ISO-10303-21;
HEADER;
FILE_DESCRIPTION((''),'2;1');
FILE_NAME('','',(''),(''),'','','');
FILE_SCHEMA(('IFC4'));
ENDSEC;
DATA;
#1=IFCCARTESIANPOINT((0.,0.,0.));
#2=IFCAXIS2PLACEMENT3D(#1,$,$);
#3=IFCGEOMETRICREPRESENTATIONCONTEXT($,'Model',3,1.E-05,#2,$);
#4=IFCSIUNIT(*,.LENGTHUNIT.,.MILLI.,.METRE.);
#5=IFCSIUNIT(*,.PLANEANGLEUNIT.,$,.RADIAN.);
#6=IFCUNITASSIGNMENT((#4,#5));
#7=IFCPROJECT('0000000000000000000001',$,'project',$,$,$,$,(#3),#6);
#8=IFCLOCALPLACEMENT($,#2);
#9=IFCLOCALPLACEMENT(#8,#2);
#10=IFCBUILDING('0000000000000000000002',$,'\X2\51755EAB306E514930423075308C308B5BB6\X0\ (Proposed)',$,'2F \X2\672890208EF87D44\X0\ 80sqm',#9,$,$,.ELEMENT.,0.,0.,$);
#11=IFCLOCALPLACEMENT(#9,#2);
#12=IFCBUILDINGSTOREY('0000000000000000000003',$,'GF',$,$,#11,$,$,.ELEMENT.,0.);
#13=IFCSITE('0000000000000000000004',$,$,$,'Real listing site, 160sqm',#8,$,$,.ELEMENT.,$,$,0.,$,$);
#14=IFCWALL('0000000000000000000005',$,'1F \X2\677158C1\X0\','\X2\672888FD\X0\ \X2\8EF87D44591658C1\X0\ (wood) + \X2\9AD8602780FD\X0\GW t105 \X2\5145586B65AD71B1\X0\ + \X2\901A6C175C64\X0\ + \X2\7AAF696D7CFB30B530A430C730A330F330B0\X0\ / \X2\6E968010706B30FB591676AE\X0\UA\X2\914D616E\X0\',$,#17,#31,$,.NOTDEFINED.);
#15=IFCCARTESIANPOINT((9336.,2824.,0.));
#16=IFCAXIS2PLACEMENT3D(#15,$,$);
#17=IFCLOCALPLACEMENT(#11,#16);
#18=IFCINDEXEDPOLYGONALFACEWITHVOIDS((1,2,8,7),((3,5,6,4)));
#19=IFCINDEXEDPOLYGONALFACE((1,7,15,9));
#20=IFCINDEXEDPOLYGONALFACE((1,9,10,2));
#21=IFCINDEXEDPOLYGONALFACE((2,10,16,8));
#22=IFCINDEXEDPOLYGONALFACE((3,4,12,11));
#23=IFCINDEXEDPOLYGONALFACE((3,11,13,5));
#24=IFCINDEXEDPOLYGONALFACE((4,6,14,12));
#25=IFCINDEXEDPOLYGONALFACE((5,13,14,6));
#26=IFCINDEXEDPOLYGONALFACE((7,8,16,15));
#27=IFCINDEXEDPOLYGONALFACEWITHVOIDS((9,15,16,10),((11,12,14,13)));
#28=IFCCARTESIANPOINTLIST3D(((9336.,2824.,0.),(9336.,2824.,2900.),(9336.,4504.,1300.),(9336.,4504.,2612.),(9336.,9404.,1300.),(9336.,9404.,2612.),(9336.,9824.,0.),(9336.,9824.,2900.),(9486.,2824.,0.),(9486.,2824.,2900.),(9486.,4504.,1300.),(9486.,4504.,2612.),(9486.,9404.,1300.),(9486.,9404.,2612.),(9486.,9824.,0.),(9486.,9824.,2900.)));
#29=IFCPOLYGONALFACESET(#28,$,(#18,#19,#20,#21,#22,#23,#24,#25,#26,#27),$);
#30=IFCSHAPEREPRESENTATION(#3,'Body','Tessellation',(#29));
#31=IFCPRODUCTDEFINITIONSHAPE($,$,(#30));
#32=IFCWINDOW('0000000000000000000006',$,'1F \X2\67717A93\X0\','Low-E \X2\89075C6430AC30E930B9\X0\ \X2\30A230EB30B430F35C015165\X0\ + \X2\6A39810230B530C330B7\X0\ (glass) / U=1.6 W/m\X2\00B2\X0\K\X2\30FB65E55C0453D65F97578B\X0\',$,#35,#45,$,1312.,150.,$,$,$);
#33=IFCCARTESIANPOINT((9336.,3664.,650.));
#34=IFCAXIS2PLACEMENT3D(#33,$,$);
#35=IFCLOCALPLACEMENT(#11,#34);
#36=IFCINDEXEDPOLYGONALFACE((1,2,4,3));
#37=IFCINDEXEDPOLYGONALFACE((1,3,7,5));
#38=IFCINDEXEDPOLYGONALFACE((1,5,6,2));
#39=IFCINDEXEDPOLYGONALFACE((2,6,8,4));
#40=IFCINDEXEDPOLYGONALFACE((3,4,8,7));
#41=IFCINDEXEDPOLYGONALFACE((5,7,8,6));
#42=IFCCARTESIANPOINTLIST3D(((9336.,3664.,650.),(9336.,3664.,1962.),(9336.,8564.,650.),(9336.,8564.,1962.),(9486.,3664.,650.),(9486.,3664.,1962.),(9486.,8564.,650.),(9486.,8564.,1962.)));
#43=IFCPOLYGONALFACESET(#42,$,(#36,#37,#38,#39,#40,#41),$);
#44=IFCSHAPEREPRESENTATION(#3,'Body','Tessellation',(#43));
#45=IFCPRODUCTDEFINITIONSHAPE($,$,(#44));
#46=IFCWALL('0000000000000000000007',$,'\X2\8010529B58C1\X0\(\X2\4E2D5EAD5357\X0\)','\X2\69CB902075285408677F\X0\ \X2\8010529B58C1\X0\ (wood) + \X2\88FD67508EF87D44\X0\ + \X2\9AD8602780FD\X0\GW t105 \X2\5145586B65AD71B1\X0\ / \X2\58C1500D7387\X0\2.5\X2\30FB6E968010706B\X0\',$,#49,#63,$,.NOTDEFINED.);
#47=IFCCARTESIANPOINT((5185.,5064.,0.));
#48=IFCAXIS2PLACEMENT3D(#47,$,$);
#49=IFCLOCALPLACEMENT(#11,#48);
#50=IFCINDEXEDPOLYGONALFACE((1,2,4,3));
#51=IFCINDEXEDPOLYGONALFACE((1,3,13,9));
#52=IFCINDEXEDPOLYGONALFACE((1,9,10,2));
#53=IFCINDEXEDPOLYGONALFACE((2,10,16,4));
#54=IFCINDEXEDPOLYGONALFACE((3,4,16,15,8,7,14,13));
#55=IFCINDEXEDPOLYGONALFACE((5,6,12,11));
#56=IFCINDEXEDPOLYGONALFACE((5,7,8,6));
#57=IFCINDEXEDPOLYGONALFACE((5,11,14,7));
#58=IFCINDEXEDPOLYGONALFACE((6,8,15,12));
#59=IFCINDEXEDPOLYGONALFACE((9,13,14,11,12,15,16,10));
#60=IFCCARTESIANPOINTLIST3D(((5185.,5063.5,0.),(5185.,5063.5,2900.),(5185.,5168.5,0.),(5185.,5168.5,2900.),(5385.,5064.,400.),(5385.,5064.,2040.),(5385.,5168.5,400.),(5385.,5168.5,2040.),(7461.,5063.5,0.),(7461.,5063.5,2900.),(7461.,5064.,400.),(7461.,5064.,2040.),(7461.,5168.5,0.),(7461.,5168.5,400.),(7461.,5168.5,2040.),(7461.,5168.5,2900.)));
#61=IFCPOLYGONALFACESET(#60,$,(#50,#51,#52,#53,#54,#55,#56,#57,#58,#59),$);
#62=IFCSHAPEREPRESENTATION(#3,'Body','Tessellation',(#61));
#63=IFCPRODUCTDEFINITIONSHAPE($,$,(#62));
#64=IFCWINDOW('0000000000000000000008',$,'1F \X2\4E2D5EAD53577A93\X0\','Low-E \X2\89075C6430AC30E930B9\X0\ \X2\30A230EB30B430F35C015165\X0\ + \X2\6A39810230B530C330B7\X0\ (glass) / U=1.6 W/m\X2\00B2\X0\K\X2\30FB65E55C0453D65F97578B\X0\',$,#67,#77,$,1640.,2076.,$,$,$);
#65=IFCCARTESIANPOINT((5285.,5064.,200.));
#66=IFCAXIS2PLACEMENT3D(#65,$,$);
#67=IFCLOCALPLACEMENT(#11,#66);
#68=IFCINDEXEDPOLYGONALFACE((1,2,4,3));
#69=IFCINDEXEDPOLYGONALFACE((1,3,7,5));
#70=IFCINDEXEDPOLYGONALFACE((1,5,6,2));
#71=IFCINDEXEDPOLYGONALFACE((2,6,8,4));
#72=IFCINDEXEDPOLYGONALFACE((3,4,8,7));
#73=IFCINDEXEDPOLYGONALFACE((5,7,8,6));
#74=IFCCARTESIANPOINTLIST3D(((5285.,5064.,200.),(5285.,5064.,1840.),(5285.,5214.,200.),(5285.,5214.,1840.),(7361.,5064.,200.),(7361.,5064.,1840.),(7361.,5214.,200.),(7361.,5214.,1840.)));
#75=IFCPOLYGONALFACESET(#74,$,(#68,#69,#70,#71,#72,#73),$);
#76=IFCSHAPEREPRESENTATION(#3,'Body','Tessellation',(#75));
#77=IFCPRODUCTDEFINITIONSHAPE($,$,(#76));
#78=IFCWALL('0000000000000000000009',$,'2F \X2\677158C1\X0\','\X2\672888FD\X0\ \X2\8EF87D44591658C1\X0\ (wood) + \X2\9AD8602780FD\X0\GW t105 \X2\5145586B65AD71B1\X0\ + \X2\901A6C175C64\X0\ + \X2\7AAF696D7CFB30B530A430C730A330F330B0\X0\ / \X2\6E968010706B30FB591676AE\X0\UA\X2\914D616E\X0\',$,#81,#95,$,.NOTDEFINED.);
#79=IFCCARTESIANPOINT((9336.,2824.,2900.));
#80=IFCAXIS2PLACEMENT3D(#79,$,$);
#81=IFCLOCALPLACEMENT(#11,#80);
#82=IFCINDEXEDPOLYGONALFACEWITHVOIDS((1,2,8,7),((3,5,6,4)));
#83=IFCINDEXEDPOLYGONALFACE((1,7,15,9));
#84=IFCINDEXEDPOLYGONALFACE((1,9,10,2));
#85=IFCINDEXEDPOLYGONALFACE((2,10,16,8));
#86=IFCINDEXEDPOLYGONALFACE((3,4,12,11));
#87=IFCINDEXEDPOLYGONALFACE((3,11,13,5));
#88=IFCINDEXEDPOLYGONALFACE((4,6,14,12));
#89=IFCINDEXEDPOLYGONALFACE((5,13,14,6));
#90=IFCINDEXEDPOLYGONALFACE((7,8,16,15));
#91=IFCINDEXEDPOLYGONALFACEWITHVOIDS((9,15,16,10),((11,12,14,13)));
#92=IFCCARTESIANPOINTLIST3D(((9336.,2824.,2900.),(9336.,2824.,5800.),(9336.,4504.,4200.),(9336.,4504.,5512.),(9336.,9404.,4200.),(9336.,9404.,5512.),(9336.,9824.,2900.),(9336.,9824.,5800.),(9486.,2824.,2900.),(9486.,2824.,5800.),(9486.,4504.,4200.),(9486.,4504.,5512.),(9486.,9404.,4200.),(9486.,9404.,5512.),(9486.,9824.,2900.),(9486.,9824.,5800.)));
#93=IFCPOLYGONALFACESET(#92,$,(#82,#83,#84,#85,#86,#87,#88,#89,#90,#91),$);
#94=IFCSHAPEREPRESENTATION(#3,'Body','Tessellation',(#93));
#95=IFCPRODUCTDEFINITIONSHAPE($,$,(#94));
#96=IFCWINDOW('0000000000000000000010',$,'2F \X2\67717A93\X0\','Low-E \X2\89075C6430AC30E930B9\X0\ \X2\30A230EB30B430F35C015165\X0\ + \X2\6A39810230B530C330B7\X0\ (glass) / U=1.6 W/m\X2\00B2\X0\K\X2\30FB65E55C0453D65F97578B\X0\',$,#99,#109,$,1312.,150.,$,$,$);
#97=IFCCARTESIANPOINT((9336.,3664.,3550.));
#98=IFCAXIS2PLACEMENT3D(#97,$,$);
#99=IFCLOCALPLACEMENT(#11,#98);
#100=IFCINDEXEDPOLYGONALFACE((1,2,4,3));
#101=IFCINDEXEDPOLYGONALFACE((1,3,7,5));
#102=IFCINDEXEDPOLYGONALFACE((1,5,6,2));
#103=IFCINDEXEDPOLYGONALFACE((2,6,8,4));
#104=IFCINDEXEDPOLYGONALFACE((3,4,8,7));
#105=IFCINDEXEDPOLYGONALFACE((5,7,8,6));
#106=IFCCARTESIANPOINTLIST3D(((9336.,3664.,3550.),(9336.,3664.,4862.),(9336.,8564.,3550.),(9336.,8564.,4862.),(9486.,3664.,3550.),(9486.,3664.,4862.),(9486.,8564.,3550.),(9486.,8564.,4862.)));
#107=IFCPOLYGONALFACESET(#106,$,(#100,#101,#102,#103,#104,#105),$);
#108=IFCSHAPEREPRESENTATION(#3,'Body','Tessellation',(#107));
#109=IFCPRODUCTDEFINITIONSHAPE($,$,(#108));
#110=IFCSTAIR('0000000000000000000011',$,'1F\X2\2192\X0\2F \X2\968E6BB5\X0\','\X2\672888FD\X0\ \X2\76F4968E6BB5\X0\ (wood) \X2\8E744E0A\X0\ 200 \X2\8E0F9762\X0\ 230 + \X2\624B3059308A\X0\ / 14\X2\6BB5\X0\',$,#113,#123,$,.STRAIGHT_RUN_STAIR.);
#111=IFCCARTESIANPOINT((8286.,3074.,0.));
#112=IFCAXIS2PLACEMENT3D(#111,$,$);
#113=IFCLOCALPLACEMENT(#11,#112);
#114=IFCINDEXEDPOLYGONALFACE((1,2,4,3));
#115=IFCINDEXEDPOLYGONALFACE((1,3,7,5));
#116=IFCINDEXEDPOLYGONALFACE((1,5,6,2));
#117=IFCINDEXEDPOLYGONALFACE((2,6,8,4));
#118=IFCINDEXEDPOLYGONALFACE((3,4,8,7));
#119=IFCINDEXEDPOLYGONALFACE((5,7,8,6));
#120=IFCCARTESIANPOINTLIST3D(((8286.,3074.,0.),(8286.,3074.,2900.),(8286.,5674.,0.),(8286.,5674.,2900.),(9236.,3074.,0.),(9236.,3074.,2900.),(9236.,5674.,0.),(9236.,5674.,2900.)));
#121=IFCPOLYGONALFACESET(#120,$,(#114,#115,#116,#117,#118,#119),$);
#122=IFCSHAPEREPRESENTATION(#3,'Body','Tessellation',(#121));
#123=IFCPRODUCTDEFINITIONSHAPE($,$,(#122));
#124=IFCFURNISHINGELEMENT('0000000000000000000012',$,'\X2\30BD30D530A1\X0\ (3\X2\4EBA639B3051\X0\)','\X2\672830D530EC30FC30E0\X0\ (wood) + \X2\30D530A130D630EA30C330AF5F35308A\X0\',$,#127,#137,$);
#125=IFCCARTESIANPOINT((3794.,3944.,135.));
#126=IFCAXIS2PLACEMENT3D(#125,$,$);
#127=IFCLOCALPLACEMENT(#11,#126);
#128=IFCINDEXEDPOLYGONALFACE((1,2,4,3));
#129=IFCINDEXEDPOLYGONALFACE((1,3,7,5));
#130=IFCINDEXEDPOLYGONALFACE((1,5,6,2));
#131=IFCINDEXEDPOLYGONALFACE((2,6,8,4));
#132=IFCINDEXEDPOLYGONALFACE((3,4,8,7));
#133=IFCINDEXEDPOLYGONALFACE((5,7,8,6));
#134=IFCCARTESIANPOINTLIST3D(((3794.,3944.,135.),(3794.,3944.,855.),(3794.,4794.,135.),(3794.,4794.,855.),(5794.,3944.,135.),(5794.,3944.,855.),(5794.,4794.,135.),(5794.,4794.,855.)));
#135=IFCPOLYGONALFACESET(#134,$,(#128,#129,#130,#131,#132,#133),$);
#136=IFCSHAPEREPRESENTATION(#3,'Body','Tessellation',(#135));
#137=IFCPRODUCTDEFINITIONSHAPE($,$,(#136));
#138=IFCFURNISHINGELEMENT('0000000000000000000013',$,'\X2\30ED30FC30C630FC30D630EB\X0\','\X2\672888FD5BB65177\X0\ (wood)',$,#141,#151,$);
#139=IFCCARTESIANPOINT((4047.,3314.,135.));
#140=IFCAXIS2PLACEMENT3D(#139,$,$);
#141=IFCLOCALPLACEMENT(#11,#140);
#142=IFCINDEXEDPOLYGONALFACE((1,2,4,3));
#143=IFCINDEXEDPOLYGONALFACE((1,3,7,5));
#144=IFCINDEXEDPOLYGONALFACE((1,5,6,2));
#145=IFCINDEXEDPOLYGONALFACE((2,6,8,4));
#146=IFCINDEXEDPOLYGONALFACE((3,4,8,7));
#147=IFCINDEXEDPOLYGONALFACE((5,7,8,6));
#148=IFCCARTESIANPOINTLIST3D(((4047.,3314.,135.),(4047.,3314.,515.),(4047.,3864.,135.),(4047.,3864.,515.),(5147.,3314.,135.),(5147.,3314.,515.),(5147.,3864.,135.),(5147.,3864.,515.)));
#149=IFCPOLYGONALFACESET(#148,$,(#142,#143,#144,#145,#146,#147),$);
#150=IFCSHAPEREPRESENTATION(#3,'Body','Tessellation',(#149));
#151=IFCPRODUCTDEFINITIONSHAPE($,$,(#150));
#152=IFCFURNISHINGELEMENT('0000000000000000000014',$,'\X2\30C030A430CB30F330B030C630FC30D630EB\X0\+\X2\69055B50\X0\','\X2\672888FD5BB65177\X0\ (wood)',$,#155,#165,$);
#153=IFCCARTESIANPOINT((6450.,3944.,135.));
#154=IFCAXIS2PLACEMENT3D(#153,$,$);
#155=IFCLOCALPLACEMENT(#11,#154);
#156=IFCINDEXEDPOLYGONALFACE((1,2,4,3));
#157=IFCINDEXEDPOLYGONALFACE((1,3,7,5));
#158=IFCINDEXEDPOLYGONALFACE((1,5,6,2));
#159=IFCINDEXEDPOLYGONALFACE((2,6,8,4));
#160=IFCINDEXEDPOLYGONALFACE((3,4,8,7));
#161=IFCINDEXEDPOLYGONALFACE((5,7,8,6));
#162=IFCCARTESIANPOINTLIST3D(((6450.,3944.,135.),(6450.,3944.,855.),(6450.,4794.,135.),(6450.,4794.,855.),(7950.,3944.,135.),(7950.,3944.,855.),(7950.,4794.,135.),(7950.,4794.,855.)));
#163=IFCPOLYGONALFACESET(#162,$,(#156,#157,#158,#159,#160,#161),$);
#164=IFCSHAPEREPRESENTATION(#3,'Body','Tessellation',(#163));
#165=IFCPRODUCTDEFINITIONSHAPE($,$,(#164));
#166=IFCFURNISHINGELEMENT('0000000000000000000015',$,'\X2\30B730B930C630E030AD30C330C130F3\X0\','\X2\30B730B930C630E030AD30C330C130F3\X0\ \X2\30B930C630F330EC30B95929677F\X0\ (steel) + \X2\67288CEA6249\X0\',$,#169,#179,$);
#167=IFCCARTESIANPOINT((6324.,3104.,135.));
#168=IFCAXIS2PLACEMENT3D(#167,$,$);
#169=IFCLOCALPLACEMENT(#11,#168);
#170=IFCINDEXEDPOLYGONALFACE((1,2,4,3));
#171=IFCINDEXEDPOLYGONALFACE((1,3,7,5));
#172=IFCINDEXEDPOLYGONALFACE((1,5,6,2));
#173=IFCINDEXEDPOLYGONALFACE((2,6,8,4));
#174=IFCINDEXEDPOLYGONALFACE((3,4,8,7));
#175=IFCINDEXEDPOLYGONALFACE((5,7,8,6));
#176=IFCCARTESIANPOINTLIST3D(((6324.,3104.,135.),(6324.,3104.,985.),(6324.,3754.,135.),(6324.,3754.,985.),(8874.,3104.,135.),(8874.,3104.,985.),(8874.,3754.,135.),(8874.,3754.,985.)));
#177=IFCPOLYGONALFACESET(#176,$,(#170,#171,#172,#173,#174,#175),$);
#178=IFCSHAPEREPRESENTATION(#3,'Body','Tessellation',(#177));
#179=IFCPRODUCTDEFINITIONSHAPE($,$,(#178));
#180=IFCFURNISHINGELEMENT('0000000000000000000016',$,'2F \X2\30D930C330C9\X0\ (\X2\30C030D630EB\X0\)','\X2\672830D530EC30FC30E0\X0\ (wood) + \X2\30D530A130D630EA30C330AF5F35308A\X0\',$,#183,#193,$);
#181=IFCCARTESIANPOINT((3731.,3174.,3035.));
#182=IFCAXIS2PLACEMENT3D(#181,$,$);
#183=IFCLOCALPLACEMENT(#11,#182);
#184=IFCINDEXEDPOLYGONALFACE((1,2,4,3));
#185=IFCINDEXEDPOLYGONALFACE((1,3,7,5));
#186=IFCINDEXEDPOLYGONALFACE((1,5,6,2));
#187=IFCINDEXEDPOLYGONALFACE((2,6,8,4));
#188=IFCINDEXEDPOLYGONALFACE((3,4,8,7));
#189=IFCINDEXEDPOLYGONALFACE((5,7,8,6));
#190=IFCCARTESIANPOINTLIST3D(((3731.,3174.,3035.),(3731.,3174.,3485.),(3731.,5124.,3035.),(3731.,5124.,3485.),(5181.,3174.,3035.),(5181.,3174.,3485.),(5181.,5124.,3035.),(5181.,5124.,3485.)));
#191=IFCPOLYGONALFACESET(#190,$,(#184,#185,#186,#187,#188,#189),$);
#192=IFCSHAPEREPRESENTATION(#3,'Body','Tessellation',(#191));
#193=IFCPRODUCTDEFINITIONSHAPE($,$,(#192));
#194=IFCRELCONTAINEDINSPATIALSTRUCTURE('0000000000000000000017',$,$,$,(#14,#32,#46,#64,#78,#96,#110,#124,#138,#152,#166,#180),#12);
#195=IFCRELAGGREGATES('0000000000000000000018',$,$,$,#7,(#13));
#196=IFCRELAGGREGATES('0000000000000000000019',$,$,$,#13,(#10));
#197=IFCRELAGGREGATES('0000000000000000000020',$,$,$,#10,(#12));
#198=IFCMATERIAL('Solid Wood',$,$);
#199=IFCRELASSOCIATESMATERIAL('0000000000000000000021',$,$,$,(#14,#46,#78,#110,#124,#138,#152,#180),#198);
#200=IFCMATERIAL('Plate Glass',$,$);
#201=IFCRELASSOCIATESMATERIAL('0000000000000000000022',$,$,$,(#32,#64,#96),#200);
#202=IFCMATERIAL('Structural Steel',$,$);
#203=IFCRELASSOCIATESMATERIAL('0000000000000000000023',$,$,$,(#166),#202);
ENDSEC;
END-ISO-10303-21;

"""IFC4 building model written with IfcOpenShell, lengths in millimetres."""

from ifc_helpers import new_model, si_unit, frame, frame_2d, origin, place, context, project, spatial, rectangle, extrude, material, element, fill, save


model = new_model("IFC4")

# Units and contexts
model_context = context("Model", 3, precision=1e-05, world=origin())
ifc_project = project(units=[si_unit("LENGTHUNIT", "METRE", prefix="MILLI"), si_unit("PLANEANGLEUNIT", "RADIAN")], contexts=[model_context])

# Site, building, storey
site_placement = place(None, origin())
site = spatial("IfcSite", under=ifc_project, at=site_placement, ObjectType="Real listing site, 160sqm", CompositionType="ELEMENT", RefElevation=0.0)
building_placement = place(site_placement, origin())
building = spatial("IfcBuilding", under=site, at=building_placement, Name="兵庫の光あふれる家 (Proposed)", ObjectType="2F 木造軸組 80sqm", CompositionType="ELEMENT", ElevationOfRefHeight=0.0, ElevationOfTerrain=0.0)
storey_placement = place(building_placement, origin())
storey = spatial("IfcBuildingStorey", under=building, at=storey_placement, Name="GF", CompositionType="ELEMENT", Elevation=0.0)

# Shared definitions
ifc_material_1 = material(Name="Solid Wood")

# Walls, openings, windows
wall_1_placement = place(storey_placement, frame((9336.0, 2824.0, 0.0)))
wall_1 = element("IfcWall", 1, at=wall_1_placement, inside=storey, material=ifc_material_1, Name="1F 東壁", Description="木製 軸組外壁 (wood) + 高性能GW t105 充填断熱 + 通気層 + 窯業系サイディング / 準耐火・外皮UA配慮", PredefinedType="NOTDEFINED", context=model_context, shape_type="SweptSolid", body=[
    extrude(rectangle(XDim=150.0, YDim=7000.0, at=frame_2d((75.0, 3500.0))), frame((9336.0, 2824.0, 0.0)), (0.0, 0.0, 1.0), 2900.0),
])
opening_1_placement = place(storey_placement, frame((9336.0, 3664.0, 650.0)))
opening_1 = element("IfcOpeningElement", 2, at=opening_1_placement, cuts=wall_1, PredefinedType="NOTDEFINED", context=model_context, shape_type="SweptSolid", body=[
    extrude(rectangle(XDim=150.0, YDim=4900.0, at=frame_2d((75.0, 2450.0))), frame((9336.0, 3664.0, 650.0)), (0.0, 0.0, 1.0), 1312.0),
])
ifc_material_2 = material(Name="Plate Glass")
window_1_placement = place(storey_placement, frame((9336.0, 3664.0, 650.0)))
window_1 = element("IfcWindow", 3, at=window_1_placement, inside=storey, material=ifc_material_2, Name="1F 東窓", Description="Low-E 複層ガラス アルゴン封入 + 樹脂サッシ (glass) / U=1.6 W/m²K・日射取得型", OverallHeight=1312.0, OverallWidth=150.0, context=model_context, shape_type="SweptSolid", body=[
    extrude(rectangle(XDim=150.0, YDim=4900.0, at=frame_2d((75.0, 2450.0))), frame((9336.0, 3664.0, 650.0)), (0.0, 0.0, 1.0), 1312.0),
])
fill(opening_1, window_1)
wall_2_placement = place(storey_placement, frame((5185.0, 5064.0, 0.0)))
wall_2 = element("IfcWall", 4, at=wall_2_placement, inside=storey, material=ifc_material_1, Name="耐力壁(中庭南)", Description="構造用合板 耐力壁 (wood) + 製材軸組 + 高性能GW t105 充填断熱 / 壁倍率2.5・準耐火", PredefinedType="NOTDEFINED", context=model_context, shape_type="SweptSolid", body=[
    extrude(rectangle(XDim=2276.0, YDim=105.0, at=frame_2d((1138.0, 52.0))), frame((5185.0, 5064.0, 0.0)), (0.0, 0.0, 1.0), 2900.0),
])
opening_2_placement = place(storey_placement, frame((5285.0, 5064.0, 200.0)))
opening_2 = element("IfcOpeningElement", 5, at=opening_2_placement, cuts=wall_2, PredefinedType="NOTDEFINED", context=model_context, shape_type="SweptSolid", body=[
    extrude(rectangle(XDim=2076.0, YDim=150.0, at=frame_2d((1038.0, 75.0))), frame((5285.0, 5064.0, 200.0)), (0.0, 0.0, 1.0), 1640.0),
])
window_2_placement = place(storey_placement, frame((5285.0, 5064.0, 200.0)))
window_2 = element("IfcWindow", 6, at=window_2_placement, inside=storey, material=ifc_material_2, Name="1F 中庭南窓", Description="Low-E 複層ガラス アルゴン封入 + 樹脂サッシ (glass) / U=1.6 W/m²K・日射取得型", OverallHeight=1640.0, OverallWidth=2076.0, context=model_context, shape_type="SweptSolid", body=[
    extrude(rectangle(XDim=2076.0, YDim=150.0, at=frame_2d((1038.0, 75.0))), frame((5285.0, 5064.0, 200.0)), (0.0, 0.0, 1.0), 1640.0),
])
fill(opening_2, window_2)

# Wall, opening, window
wall_3_placement = place(storey_placement, frame((9336.0, 2824.0, 2900.0)))
wall_3 = element("IfcWall", 7, at=wall_3_placement, inside=storey, material=ifc_material_1, Name="2F 東壁", Description="木製 軸組外壁 (wood) + 高性能GW t105 充填断熱 + 通気層 + 窯業系サイディング / 準耐火・外皮UA配慮", PredefinedType="NOTDEFINED", context=model_context, shape_type="SweptSolid", body=[
    extrude(rectangle(XDim=150.0, YDim=7000.0, at=frame_2d((75.0, 3500.0))), frame((9336.0, 2824.0, 2900.0)), (0.0, 0.0, 1.0), 2900.0),
])
opening_3_placement = place(storey_placement, frame((9336.0, 3664.0, 3550.0)))
opening_3 = element("IfcOpeningElement", 8, at=opening_3_placement, cuts=wall_3, PredefinedType="NOTDEFINED", context=model_context, shape_type="SweptSolid", body=[
    extrude(rectangle(XDim=150.0, YDim=4900.0, at=frame_2d((75.0, 2450.0))), frame((9336.0, 3664.0, 3550.0)), (0.0, 0.0, 1.0), 1312.0),
])
window_3_placement = place(storey_placement, frame((9336.0, 3664.0, 3550.0)))
window_3 = element("IfcWindow", 9, at=window_3_placement, inside=storey, material=ifc_material_2, Name="2F 東窓", Description="Low-E 複層ガラス アルゴン封入 + 樹脂サッシ (glass) / U=1.6 W/m²K・日射取得型", OverallHeight=1312.0, OverallWidth=150.0, context=model_context, shape_type="SweptSolid", body=[
    extrude(rectangle(XDim=150.0, YDim=4900.0, at=frame_2d((75.0, 2450.0))), frame((9336.0, 3664.0, 3550.0)), (0.0, 0.0, 1.0), 1312.0),
])
fill(opening_3, window_3)

# Stair
stair_placement = place(storey_placement, frame((8286.0, 3074.0, 0.0)))
element("IfcStair", 10, at=stair_placement, inside=storey, material=ifc_material_1, Name="1F→2F 階段", Description="木製 直階段 (wood) 蹴上 200 踏面 230 + 手すり / 14段", PredefinedType="STRAIGHT_RUN_STAIR", context=model_context, shape_type="SweptSolid", body=[
    extrude(rectangle(XDim=950.0, YDim=2600.0, at=frame_2d((475.0, 1300.0))), frame((8286.0, 3074.0, 0.0)), (0.0, 0.0, 1.0), 2900.0),
])

# Furnishing elements
furnishing_1_placement = place(storey_placement, frame((3794.0, 3944.0, 135.0)))
element("IfcFurnishingElement", 11, at=furnishing_1_placement, inside=storey, material=ifc_material_1, Name="ソファ (3人掛け)", Description="木フレーム (wood) + ファブリック張り", context=model_context, shape_type="SweptSolid", body=[
    extrude(rectangle(XDim=2000.0, YDim=850.0, at=frame_2d((1000.0, 425.0))), frame((3794.0, 3944.0, 135.0)), (0.0, 0.0, 1.0), 720.0),
])
furnishing_2_placement = place(storey_placement, frame((4047.0, 3314.0, 135.0)))
element("IfcFurnishingElement", 12, at=furnishing_2_placement, inside=storey, material=ifc_material_1, Name="ローテーブル", Description="木製家具 (wood)", context=model_context, shape_type="SweptSolid", body=[
    extrude(rectangle(XDim=1100.0, YDim=550.0, at=frame_2d((550.0, 275.0))), frame((4047.0, 3314.0, 135.0)), (0.0, 0.0, 1.0), 380.0),
])
furnishing_3_placement = place(storey_placement, frame((6450.0, 3944.0, 135.0)))
element("IfcFurnishingElement", 13, at=furnishing_3_placement, inside=storey, material=ifc_material_1, Name="ダイニングテーブル+椅子", Description="木製家具 (wood)", context=model_context, shape_type="SweptSolid", body=[
    extrude(rectangle(XDim=1500.0, YDim=850.0, at=frame_2d((750.0, 425.0))), frame((6450.0, 3944.0, 135.0)), (0.0, 0.0, 1.0), 720.0),
])
ifc_material_3 = material(Name="Structural Steel")
furnishing_4_placement = place(storey_placement, frame((6324.0, 3104.0, 135.0)))
element("IfcFurnishingElement", 14, at=furnishing_4_placement, inside=storey, material=ifc_material_3, Name="システムキッチン", Description="システムキッチン ステンレス天板 (steel) + 木質扉", context=model_context, shape_type="SweptSolid", body=[
    extrude(rectangle(XDim=2550.0, YDim=650.0, at=frame_2d((1275.0, 325.0))), frame((6324.0, 3104.0, 135.0)), (0.0, 0.0, 1.0), 850.0),
])
furnishing_5_placement = place(storey_placement, frame((3731.0, 3174.0, 3035.0)))
element("IfcFurnishingElement", 15, at=furnishing_5_placement, inside=storey, material=ifc_material_1, Name="2F ベッド (ダブル)", Description="木フレーム (wood) + ファブリック張り", context=model_context, shape_type="SweptSolid", body=[
    extrude(rectangle(XDim=1450.0, YDim=1950.0, at=frame_2d((725.0, 975.0))), frame((3731.0, 3174.0, 3035.0)), (0.0, 0.0, 1.0), 450.0),
])

save(model, "model.ifc")
